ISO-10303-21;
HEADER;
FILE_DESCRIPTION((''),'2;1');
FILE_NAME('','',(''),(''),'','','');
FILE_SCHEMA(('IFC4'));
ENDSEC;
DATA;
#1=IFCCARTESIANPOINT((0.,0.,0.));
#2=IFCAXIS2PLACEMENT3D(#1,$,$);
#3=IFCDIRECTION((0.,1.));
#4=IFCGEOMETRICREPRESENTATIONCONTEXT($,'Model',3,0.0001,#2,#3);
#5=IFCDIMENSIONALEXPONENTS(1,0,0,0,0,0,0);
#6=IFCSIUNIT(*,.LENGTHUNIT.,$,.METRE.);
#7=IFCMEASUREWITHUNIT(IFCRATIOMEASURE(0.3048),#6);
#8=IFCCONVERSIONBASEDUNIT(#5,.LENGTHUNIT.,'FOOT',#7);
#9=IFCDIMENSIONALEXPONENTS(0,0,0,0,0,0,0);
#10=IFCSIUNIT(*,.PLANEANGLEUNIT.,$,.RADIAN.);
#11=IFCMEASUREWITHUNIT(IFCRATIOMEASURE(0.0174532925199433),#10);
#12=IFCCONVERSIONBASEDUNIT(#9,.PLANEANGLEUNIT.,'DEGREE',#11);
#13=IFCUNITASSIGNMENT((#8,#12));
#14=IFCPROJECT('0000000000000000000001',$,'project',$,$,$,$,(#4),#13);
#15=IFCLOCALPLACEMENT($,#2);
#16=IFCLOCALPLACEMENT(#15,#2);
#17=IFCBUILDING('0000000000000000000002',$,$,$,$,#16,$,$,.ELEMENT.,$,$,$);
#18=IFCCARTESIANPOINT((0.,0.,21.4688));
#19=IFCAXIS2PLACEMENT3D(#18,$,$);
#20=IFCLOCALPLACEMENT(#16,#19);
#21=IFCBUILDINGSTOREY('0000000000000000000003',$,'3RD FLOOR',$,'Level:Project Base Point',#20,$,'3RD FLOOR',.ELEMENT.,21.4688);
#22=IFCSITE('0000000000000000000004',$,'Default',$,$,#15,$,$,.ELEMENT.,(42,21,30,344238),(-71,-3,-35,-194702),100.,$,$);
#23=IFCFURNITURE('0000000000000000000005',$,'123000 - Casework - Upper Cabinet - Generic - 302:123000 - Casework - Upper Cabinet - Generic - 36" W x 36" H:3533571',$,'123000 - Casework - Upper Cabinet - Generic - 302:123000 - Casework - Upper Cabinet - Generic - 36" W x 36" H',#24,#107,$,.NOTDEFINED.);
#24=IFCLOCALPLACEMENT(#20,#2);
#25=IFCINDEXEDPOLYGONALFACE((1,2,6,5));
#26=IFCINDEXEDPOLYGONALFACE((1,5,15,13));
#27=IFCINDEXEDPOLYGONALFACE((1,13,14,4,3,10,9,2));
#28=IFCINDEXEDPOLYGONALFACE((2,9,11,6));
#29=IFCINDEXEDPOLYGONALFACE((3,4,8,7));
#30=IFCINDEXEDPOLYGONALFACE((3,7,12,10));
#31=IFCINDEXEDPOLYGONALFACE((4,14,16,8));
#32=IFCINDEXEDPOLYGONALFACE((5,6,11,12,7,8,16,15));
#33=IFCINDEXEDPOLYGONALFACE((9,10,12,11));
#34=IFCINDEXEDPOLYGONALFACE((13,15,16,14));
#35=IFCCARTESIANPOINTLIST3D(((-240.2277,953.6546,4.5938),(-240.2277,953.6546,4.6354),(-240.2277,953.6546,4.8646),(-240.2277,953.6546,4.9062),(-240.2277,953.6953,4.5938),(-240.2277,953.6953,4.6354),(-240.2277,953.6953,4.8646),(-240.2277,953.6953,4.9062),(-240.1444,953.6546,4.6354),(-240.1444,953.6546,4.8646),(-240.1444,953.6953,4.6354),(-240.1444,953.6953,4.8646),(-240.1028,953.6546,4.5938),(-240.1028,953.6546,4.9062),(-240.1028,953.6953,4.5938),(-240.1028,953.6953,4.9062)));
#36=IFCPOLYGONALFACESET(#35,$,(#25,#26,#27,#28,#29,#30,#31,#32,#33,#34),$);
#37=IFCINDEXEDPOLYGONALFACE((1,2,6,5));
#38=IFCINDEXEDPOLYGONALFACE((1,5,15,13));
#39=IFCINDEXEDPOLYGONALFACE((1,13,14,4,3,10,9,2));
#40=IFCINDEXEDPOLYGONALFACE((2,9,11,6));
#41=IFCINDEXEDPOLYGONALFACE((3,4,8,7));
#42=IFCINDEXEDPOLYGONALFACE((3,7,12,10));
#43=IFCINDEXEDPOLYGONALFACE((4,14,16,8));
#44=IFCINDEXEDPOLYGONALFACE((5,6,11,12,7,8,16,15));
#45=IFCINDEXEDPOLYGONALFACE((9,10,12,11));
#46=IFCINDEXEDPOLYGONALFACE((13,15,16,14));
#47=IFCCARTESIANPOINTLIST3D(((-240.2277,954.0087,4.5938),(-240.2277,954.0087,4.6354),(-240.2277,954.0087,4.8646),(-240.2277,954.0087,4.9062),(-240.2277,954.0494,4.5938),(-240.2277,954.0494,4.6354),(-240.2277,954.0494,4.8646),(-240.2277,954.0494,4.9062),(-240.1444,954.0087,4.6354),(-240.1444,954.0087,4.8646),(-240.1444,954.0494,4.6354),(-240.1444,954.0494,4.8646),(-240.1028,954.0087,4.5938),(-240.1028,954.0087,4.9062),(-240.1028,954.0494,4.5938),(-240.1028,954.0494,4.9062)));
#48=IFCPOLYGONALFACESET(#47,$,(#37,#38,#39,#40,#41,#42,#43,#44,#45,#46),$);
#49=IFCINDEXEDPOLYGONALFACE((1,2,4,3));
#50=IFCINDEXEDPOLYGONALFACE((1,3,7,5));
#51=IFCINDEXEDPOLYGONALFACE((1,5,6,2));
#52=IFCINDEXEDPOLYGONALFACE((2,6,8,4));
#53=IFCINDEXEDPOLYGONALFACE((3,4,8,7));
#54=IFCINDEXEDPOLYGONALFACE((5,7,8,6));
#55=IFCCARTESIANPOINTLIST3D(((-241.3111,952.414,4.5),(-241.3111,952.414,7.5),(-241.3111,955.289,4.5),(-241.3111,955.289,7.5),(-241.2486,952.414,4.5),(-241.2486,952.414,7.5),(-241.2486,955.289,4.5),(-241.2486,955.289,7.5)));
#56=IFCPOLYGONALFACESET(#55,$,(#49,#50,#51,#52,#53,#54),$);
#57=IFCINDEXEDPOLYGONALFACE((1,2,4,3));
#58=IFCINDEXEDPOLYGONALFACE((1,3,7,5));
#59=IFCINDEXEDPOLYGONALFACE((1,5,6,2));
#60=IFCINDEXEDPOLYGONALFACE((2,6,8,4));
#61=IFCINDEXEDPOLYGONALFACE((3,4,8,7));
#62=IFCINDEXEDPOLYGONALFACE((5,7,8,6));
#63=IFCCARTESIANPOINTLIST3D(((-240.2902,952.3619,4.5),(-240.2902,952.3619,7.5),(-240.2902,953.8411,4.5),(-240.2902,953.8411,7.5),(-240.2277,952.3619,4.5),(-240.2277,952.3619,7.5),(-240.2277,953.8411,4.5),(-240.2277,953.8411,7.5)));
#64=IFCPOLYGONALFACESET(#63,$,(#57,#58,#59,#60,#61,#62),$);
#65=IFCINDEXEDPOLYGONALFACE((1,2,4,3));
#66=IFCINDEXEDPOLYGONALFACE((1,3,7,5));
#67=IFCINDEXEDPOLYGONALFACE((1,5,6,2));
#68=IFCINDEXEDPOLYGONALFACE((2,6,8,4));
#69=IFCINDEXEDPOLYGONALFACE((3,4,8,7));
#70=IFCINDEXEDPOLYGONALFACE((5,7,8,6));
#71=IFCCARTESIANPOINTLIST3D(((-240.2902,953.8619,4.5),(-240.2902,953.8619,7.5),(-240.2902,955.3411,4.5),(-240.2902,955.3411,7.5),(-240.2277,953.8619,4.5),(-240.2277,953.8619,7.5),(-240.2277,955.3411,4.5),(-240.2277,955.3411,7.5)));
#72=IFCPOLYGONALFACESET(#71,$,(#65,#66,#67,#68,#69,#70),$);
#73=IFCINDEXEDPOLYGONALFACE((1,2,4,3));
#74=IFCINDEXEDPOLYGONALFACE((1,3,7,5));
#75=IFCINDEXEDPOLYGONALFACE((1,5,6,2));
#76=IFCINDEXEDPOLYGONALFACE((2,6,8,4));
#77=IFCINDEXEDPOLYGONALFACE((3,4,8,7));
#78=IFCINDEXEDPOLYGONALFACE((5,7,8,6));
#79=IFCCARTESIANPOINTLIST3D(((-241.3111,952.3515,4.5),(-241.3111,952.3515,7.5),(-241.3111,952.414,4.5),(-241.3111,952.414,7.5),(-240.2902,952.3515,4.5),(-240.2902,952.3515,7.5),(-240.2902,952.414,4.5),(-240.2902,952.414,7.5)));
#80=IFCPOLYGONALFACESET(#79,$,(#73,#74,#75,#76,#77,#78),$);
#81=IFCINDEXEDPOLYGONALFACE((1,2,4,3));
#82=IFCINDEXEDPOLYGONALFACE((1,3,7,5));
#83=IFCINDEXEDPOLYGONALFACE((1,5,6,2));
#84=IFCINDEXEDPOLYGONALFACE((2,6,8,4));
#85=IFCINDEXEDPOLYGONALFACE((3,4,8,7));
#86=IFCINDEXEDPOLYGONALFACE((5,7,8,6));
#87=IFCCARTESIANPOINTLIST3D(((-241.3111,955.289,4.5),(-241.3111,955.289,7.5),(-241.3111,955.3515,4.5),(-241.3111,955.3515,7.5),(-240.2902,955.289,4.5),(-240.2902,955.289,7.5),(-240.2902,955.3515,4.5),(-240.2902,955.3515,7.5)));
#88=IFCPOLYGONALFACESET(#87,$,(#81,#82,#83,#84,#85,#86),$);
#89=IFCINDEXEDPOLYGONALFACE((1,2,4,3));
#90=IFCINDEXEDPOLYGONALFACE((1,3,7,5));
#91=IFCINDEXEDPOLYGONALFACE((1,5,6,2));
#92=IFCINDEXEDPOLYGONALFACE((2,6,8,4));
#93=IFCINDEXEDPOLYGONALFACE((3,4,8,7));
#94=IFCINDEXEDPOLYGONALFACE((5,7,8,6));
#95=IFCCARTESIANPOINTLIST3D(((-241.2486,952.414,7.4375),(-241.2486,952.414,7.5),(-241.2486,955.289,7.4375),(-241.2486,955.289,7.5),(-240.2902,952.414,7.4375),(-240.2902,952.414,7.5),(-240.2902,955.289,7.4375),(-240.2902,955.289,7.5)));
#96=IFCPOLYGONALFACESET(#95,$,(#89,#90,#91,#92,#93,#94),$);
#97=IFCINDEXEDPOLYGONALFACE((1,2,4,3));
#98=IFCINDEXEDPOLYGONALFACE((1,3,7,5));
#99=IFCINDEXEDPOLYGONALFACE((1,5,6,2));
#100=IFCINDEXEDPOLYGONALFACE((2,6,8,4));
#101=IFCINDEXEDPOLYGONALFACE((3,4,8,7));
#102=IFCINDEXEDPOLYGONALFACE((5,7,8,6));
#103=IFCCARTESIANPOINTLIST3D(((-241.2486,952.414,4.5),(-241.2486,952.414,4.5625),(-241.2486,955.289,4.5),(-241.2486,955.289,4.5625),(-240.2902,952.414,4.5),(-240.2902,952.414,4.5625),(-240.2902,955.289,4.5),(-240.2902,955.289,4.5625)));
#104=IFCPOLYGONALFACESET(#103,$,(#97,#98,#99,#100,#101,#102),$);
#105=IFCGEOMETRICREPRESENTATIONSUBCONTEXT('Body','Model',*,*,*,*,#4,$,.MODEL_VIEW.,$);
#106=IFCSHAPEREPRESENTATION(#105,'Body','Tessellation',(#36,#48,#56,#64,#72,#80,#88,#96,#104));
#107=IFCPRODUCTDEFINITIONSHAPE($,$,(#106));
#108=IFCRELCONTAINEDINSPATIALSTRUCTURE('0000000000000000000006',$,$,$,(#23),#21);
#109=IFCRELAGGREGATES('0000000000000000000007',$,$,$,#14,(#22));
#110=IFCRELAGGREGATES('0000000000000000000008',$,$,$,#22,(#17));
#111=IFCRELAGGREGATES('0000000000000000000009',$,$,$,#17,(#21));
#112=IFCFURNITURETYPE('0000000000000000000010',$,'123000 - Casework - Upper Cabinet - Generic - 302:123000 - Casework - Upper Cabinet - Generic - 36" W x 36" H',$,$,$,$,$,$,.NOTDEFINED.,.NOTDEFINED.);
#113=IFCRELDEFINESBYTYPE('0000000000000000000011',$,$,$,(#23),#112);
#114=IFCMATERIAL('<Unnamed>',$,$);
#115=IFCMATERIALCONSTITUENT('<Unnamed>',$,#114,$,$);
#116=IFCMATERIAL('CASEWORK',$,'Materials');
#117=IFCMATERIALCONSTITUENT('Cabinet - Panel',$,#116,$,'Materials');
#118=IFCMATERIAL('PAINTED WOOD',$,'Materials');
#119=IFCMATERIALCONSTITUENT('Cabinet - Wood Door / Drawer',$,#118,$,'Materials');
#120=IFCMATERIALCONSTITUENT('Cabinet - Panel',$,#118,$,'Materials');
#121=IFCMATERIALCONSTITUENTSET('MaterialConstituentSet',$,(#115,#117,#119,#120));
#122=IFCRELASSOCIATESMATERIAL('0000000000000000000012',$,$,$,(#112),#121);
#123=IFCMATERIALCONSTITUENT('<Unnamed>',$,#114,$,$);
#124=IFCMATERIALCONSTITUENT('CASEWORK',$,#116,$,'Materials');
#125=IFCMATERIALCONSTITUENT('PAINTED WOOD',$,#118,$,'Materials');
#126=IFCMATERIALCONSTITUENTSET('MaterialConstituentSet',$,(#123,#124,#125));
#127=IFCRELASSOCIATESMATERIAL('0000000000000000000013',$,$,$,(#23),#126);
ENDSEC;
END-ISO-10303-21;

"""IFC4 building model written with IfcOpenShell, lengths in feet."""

from ifc_helpers import new_model, entity, si_unit, converted_unit, direction, frame, frame_2d, origin, origin_2d_with_axis, place, context, subcontext, project, spatial, polyline, rectangle, outline, extrude, source, transform, mapped, material, constituent, constituent_set, type_object, type_shapes, element, save


model = new_model("IFC4")

# Units and contexts
model_context = context("Model", 3, precision=0.0001, world=origin(), true_north=direction((0.0, 1.0)))
body_context = subcontext(model_context, "Body", "Model", "MODEL_VIEW")
ifc_project = project(units=[converted_unit("LENGTHUNIT", "FOOT", entity("IfcRatioMeasure", 0.3048), si_unit("LENGTHUNIT", "METRE"), dimensions=[1, 0, 0, 0, 0, 0, 0]), converted_unit("PLANEANGLEUNIT", "DEGREE", entity("IfcRatioMeasure", 0.0174532925199433), si_unit("PLANEANGLEUNIT", "RADIAN"), dimensions=[0, 0, 0, 0, 0, 0, 0])], contexts=[model_context])

# Site, building, storey
site_placement = place(None, origin())
site = spatial("IfcSite", under=ifc_project, at=site_placement, Name="Default", CompositionType="ELEMENT", RefLatitude=(42, 21, 30, 344238), RefLongitude=(-71, -3, -35, -194702), RefElevation=100.0)
building_placement = place(site_placement, origin())
building = spatial("IfcBuilding", under=site, at=building_placement, CompositionType="ELEMENT")
storey_placement = place(building_placement, frame((0.0, 0.0, 21.4688)))
storey = spatial("IfcBuildingStorey", under=building, at=storey_placement, Name="3RD FLOOR", ObjectType="Level:Project Base Point", LongName="3RD FLOOR", CompositionType="ELEMENT", Elevation=21.4688)

# Furniture
ifc_material_1 = material(Name="PAINTED WOOD", Category="Materials")
ifc_material_2 = material(Name="CASEWORK", Category="Materials")
ifc_material_3 = material(Name="<Unnamed>")
ifc_constituent_1 = constituent(ifc_material_3, Name="<Unnamed>")
ifc_constituent_2 = constituent(ifc_material_2, Name="CASEWORK", Category="Materials")
ifc_constituent_3 = constituent(ifc_material_1, Name="PAINTED WOOD", Category="Materials")
ifc_constituent_set_1 = constituent_set(constituents=[ifc_constituent_1, ifc_constituent_2, ifc_constituent_3], Name="MaterialConstituentSet")
ifc_constituent_4 = constituent(ifc_material_3, Name="<Unnamed>")
ifc_constituent_5 = constituent(ifc_material_2, Name="Cabinet - Panel", Category="Materials")
ifc_constituent_6 = constituent(ifc_material_1, Name="Cabinet - Wood Door / Drawer", Category="Materials")
ifc_constituent_7 = constituent(ifc_material_1, Name="Cabinet - Panel", Category="Materials")
ifc_constituent_set_2 = constituent_set(constituents=[ifc_constituent_4, ifc_constituent_5, ifc_constituent_6, ifc_constituent_7], Name="MaterialConstituentSet")
furniture_type_1 = type_object("IfcFurnitureType", Name="123000 - Casework - Upper Cabinet - Generic - 302:123000 - Casework - Upper Cabinet - Generic - 36\" W x 36\" H", AssemblyPlace="NOTDEFINED", PredefinedType="NOTDEFINED", material=ifc_constituent_set_2)
shared_shape_1 = source(origin(), body_context, "Body", "SweptSolid", [
    extrude(outline(polyline([(0.1146, -0.0521), (0.1562, -0.0521), (0.1562, 0.0729), (-0.1562, 0.0729), (-0.1562, -0.0521), (-0.1146, -0.0521), (-0.1146, 0.0313), (0.1146, 0.0313), (0.1146, -0.0521)])), frame((1.303, 0.0729, 0.25), z_axis=(1.0, 0.0, 0.0), x_axis=(0.0, 0.0, 1.0)), (0.0, 0.0, 1.0), 0.0407),
    extrude(outline(polyline([(0.1146, -0.0521), (0.1562, -0.0521), (0.1562, 0.0729), (-0.1562, 0.0729), (-0.1562, -0.0521), (-0.1146, -0.0521), (-0.1146, 0.0313), (0.1146, 0.0313), (0.1146, -0.0521)])), frame((1.6572, 0.0729, 0.25), z_axis=(1.0, 0.0, 0.0), x_axis=(0.0, 0.0, 1.0)), (0.0, 0.0, 1.0), 0.0407),
    extrude(rectangle(XDim=0.0625, YDim=2.875, at=origin_2d_with_axis()), frame((1.5, 1.177, 0.0), z_axis=(0.0, 0.0, 1.0), x_axis=(0.0, 1.0, 0.0)), (0.0, 0.0, 1.0), 3.0),
    extrude(rectangle(XDim=0.0625, YDim=1.4792, at=frame_2d((0.0, 0.0), x_axis=(1.0, 0.0))), frame((0.75, 0.1562, 0.0), z_axis=(0.0, 0.0, 1.0), x_axis=(0.0, -1.0, 0.0)), (0.0, 0.0, 1.0), 3.0),
    extrude(rectangle(XDim=0.0625, YDim=1.4792, at=origin_2d_with_axis()), frame((2.25, 0.1562, 0.0), z_axis=(0.0, 0.0, 1.0), x_axis=(0.0, -1.0, 0.0)), (0.0, 0.0, 1.0), 3.0),
    extrude(rectangle(XDim=0.0625, YDim=1.0208, at=origin_2d_with_axis()), frame((0.0312, 0.6979, 0.0), z_axis=(0.0, 0.0, 1.0), x_axis=(-1.0, 0.0, 0.0)), (0.0, 0.0, 1.0), 3.0),
    extrude(rectangle(XDim=0.0625, YDim=1.0208, at=origin_2d_with_axis()), frame((2.9688, 0.6979, 0.0), z_axis=(0.0, 0.0, 1.0), x_axis=(-1.0, 0.0, 0.0)), (0.0, 0.0, 1.0), 3.0),
    extrude(rectangle(XDim=2.875, YDim=0.9583, at=frame_2d((0.0, 0.0), x_axis=(1.0, 0.0))), frame((1.5, 0.6666, 2.9375), z_axis=(0.0, 0.0, 1.0), x_axis=(-1.0, 0.0, 0.0)), (0.0, 0.0, 1.0), 0.0625),
    extrude(rectangle(XDim=2.875, YDim=0.9583, at=frame_2d((0.0, 0.0), x_axis=(1.0, 0.0))), frame((1.5, 0.6666, 0.0), z_axis=(0.0, 0.0, 1.0), x_axis=(-1.0, 0.0, 0.0)), (0.0, 0.0, 1.0), 0.0625),
])
type_shapes(furniture_type_1, [shared_shape_1])
furniture_1_placement = place(storey_placement, frame((-240.1028, 952.3515, 4.5), z_axis=(0.0, 0.0, 1.0), x_axis=(0.0, 1.0, 0.0)))
element("IfcFurniture", 1, at=furniture_1_placement, inside=storey, type_object=furniture_type_1, material=ifc_constituent_set_1, Name="123000 - Casework - Upper Cabinet - Generic - 302:123000 - Casework - Upper Cabinet - Generic - 36\" W x 36\" H:3533571", ObjectType="123000 - Casework - Upper Cabinet - Generic - 302:123000 - Casework - Upper Cabinet - Generic - 36\" W x 36\" H", PredefinedType="NOTDEFINED", context=body_context, shape_type="MappedRepresentation", body=[
    mapped(shared_shape_1, transform((0.0, 0.0, 0.0), scale=1.0)),
])

save(model, "model.ifc")
